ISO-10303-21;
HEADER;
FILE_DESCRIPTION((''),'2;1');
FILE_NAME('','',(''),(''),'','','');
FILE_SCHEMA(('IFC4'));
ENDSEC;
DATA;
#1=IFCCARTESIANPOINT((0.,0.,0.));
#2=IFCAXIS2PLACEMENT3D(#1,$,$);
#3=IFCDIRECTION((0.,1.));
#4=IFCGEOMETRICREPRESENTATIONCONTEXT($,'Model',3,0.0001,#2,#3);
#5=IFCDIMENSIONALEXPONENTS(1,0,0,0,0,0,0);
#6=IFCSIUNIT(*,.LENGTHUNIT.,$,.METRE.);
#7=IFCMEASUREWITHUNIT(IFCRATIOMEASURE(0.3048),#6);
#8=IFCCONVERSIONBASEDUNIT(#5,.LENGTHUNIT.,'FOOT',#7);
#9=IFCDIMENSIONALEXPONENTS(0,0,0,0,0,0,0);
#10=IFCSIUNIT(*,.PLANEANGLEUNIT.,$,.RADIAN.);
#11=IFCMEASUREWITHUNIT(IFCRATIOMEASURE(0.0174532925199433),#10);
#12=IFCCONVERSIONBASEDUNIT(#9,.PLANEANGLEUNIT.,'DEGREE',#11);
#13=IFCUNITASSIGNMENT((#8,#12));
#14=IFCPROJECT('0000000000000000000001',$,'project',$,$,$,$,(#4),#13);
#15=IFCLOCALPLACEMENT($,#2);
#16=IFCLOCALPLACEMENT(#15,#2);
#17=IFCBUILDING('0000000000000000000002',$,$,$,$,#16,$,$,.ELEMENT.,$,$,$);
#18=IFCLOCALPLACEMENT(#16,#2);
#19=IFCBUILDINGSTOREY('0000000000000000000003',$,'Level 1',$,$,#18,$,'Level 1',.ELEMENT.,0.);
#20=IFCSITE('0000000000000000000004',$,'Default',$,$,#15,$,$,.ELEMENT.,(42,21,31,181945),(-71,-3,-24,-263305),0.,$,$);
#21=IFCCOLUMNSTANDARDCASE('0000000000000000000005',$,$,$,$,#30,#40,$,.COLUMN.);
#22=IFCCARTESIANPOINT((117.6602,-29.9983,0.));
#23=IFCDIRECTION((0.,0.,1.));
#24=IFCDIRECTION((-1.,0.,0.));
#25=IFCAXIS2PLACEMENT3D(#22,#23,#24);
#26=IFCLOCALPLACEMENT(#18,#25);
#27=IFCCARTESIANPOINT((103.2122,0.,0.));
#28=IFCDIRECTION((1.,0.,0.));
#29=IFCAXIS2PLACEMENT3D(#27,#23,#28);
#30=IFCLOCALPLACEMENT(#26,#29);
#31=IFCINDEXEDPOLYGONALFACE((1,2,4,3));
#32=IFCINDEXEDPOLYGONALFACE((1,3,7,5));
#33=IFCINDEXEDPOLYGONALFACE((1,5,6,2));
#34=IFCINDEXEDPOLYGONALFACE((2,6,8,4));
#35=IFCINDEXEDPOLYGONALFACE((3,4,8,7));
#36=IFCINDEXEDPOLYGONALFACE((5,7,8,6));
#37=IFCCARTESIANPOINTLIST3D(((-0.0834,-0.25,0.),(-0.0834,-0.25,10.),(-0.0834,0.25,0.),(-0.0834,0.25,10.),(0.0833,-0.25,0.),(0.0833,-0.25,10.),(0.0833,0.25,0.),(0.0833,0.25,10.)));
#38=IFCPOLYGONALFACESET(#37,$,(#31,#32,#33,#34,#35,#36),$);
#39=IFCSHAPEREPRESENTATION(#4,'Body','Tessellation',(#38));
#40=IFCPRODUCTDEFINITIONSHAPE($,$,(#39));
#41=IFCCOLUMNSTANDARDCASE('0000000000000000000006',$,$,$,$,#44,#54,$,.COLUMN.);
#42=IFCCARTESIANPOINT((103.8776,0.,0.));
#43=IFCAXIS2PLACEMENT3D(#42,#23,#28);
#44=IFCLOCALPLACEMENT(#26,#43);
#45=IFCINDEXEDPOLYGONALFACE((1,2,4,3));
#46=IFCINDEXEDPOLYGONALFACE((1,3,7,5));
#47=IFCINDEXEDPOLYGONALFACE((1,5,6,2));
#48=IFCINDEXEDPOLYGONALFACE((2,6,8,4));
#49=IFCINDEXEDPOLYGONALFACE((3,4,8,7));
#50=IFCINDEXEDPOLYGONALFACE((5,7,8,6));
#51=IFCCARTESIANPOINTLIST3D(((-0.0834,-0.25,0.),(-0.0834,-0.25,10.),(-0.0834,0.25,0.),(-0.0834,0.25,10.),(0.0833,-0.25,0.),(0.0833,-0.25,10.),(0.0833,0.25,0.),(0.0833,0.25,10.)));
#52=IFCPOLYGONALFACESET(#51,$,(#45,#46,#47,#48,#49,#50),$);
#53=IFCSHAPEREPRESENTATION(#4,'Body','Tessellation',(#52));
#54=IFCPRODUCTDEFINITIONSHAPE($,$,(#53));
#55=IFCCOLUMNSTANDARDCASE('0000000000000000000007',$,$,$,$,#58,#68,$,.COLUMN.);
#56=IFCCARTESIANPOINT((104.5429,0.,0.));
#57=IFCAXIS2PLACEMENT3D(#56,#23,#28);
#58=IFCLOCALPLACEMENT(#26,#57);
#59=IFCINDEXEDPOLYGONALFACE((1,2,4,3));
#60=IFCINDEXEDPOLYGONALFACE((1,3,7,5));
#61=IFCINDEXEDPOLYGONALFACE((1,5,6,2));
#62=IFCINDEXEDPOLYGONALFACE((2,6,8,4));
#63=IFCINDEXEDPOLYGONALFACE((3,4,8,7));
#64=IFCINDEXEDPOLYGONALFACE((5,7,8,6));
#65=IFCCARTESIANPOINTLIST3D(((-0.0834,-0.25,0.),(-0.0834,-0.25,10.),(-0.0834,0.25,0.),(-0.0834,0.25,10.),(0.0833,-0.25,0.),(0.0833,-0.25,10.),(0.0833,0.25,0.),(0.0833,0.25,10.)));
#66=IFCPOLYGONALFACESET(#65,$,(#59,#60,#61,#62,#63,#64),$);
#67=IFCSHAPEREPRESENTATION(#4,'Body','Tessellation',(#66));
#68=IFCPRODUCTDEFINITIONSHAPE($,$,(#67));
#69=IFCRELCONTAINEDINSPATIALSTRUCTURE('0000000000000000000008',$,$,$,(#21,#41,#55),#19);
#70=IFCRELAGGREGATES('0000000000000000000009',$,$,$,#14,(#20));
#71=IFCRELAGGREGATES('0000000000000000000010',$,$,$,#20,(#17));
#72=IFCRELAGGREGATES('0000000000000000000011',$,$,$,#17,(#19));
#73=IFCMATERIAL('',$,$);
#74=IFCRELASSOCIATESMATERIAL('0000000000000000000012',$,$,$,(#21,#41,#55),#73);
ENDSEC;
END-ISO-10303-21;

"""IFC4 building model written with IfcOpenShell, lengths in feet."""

from ifc_helpers import new_model, entity, si_unit, converted_unit, direction, frame, origin, place, context, project, spatial, rectangle, extrude, material, element, save


model = new_model("IFC4")

# Units and contexts
model_context = context("Model", 3, precision=0.0001, world=origin(), true_north=direction((0.0, 1.0)))
ifc_project = project(units=[converted_unit("LENGTHUNIT", "FOOT", entity("IfcRatioMeasure", 0.3048), si_unit("LENGTHUNIT", "METRE"), dimensions=[1, 0, 0, 0, 0, 0, 0]), converted_unit("PLANEANGLEUNIT", "DEGREE", entity("IfcRatioMeasure", 0.0174532925199433), si_unit("PLANEANGLEUNIT", "RADIAN"), dimensions=[0, 0, 0, 0, 0, 0, 0])], contexts=[model_context])

# Site, building, storey
site_placement = place(None, origin())
site = spatial("IfcSite", under=ifc_project, at=site_placement, Name="Default", CompositionType="ELEMENT", RefLatitude=(42, 21, 31, 181945), RefLongitude=(-71, -3, -24, -263305), RefElevation=0.0)
building_placement = place(site_placement, origin())
building = spatial("IfcBuilding", under=site, at=building_placement, CompositionType="ELEMENT")
storey_placement = place(building_placement, origin())
storey = spatial("IfcBuildingStorey", under=building, at=storey_placement, Name="Level 1", LongName="Level 1", CompositionType="ELEMENT", Elevation=0.0)

# Columns
ifc_material = material(Name="")
placement = place(storey_placement, frame((117.6602, -29.9983, 0.0), z_axis=(0.0, 0.0, 1.0), x_axis=(-1.0, 0.0, 0.0)))
for number, where, z_axis, x_axis in (
    (1, (103.2122, 0.0, 0.0), (0.0, 0.0, 1.0), (1.0, 0.0, 0.0)),
    (2, (103.8776, 0.0, 0.0), (0.0, 0.0, 1.0), (1.0, 0.0, 0.0)),
    (3, (104.5429, 0.0, 0.0), (0.0, 0.0, 1.0), (1.0, 0.0, 0.0)),
):
    element("IfcColumnStandardCase", number, at=place(placement, frame(where, z_axis=z_axis, x_axis=x_axis)), inside=storey, material=ifc_material, PredefinedType="COLUMN", context=model_context, shape_type="SweptSolid", body=[
        extrude(rectangle(XDim=0.1667, YDim=0.5), origin(), (0.0, 0.0, 1.0), 10.0),
    ])

save(model, "model.ifc")
